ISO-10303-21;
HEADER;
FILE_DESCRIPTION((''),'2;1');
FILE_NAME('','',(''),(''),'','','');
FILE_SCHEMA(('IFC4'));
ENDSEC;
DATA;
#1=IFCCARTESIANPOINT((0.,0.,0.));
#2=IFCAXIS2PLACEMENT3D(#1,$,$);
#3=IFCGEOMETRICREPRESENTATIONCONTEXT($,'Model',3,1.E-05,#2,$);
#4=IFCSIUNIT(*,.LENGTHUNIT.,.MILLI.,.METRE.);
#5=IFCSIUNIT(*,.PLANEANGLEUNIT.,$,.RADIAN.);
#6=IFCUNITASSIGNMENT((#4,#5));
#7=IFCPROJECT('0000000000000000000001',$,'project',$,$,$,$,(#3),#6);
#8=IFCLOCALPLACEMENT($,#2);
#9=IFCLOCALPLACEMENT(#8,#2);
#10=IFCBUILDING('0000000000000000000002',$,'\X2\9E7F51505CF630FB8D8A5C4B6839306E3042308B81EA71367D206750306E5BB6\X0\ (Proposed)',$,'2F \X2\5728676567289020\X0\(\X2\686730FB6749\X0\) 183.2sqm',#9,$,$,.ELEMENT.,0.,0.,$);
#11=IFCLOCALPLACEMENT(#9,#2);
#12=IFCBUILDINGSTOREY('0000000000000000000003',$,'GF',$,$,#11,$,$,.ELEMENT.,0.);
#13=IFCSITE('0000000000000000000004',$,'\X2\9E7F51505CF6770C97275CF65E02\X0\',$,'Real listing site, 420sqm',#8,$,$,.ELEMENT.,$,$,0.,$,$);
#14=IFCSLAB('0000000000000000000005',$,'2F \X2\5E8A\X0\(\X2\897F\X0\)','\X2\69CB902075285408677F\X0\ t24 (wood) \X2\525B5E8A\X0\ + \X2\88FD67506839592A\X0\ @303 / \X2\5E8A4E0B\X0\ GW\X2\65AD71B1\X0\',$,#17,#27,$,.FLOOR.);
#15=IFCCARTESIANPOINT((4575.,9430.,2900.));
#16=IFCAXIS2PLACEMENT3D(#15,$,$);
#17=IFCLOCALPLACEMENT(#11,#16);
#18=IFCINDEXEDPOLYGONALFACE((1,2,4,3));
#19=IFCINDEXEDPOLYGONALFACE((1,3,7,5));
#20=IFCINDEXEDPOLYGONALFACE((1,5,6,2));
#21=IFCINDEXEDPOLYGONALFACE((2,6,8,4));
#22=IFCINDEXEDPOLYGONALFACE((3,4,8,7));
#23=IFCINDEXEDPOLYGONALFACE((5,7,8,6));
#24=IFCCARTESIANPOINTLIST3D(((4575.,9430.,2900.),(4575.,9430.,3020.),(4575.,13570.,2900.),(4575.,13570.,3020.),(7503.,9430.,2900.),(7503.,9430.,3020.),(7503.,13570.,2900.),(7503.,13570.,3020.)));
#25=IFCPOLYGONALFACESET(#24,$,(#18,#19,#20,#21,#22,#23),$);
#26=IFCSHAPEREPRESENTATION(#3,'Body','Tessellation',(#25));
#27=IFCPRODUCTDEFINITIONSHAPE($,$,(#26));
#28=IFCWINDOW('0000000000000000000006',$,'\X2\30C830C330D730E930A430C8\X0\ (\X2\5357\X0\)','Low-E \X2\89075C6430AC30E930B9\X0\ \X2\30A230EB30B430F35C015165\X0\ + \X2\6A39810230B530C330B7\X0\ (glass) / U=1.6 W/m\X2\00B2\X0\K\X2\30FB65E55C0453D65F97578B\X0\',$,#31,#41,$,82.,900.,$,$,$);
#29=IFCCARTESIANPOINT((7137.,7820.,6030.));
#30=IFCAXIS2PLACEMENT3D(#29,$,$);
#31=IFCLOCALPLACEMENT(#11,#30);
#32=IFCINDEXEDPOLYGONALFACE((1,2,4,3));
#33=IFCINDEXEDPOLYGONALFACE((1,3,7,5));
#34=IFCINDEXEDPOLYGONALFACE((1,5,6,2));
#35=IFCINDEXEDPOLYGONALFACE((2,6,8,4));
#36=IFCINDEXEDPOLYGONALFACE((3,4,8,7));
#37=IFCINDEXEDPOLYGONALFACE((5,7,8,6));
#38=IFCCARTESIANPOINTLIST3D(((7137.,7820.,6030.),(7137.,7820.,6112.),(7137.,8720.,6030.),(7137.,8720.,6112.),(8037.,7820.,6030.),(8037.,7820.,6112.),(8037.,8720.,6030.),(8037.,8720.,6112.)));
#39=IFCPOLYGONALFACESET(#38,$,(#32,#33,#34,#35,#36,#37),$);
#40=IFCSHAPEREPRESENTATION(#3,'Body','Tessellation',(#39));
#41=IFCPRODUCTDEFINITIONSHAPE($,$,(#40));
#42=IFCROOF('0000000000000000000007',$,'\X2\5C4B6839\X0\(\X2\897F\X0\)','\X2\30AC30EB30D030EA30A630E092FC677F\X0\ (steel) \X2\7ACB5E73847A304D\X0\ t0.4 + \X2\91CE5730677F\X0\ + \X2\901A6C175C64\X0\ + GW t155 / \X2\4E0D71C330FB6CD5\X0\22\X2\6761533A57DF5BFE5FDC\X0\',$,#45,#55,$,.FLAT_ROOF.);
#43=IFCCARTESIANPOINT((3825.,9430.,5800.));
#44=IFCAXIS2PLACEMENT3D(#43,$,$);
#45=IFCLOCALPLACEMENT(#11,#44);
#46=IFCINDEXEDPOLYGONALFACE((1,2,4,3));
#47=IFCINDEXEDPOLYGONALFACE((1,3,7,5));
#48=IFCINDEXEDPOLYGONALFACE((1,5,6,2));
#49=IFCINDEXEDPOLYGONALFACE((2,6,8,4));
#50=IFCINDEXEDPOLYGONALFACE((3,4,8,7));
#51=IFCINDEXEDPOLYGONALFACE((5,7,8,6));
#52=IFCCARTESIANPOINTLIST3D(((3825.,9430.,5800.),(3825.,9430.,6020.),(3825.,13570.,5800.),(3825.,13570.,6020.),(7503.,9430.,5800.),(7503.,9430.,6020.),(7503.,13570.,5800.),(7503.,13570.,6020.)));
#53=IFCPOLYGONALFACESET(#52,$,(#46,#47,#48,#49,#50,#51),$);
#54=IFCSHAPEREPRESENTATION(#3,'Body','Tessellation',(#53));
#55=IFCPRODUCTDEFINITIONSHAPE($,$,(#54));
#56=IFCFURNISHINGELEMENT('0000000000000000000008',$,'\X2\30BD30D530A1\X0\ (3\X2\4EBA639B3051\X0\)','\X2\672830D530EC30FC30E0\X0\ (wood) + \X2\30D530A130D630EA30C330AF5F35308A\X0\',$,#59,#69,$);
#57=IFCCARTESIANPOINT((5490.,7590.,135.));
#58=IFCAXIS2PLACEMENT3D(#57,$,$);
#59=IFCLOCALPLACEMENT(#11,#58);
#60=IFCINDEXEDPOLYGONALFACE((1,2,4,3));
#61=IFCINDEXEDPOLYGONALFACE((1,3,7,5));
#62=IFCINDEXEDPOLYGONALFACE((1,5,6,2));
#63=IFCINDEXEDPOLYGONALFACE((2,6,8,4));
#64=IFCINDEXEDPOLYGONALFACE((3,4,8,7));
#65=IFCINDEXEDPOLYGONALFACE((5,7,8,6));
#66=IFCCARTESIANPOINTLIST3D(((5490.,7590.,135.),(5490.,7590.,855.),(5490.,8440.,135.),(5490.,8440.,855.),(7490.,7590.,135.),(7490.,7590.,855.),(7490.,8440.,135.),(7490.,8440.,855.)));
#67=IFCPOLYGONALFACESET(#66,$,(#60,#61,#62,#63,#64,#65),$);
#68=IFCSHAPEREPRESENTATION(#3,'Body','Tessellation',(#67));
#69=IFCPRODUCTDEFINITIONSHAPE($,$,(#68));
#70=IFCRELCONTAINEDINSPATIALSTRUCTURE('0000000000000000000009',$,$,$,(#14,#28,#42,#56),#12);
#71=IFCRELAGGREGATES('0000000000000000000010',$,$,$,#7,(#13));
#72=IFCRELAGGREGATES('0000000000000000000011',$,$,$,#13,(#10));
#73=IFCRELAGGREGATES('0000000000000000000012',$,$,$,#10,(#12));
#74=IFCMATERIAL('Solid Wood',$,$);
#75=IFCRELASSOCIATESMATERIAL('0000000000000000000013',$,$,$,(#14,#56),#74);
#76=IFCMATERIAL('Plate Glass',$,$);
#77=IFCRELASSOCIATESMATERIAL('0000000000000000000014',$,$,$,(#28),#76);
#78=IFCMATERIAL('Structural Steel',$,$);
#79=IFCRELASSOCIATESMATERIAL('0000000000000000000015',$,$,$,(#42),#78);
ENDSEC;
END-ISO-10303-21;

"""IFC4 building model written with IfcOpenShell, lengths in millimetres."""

from ifc_helpers import new_model, si_unit, frame, frame_2d, origin, place, context, project, spatial, rectangle, extrude, material, element, save


model = new_model("IFC4")

# Units and contexts
model_context = context("Model", 3, precision=1e-05, world=origin())
ifc_project = project(units=[si_unit("LENGTHUNIT", "METRE", prefix="MILLI"), si_unit("PLANEANGLEUNIT", "RADIAN")], contexts=[model_context])

# Site, building, storey
site_placement = place(None, origin())
site = spatial("IfcSite", under=ifc_project, at=site_placement, Name="鹿児島県霧島市", ObjectType="Real listing site, 420sqm", CompositionType="ELEMENT", RefElevation=0.0)
building_placement = place(site_placement, origin())
building = spatial("IfcBuilding", under=site, at=building_placement, Name="鹿児島・越屋根のある自然素材の家 (Proposed)", ObjectType="2F 在来木造(桧・杉) 183.2sqm", CompositionType="ELEMENT", ElevationOfRefHeight=0.0, ElevationOfTerrain=0.0)
storey_placement = place(building_placement, origin())
storey = spatial("IfcBuildingStorey", under=building, at=storey_placement, Name="GF", CompositionType="ELEMENT", Elevation=0.0)

# Shared definitions
ifc_material_1 = material(Name="Solid Wood")

# Slab
slab_1_placement = place(storey_placement, frame((4575.0, 9430.0, 2900.0)))
element("IfcSlab", 1, at=slab_1_placement, inside=storey, material=ifc_material_1, Name="2F 床(西)", Description="構造用合板 t24 (wood) 剛床 + 製材根太 @303 / 床下 GW断熱", PredefinedType="FLOOR", context=model_context, shape_type="SweptSolid", body=[
    extrude(rectangle(XDim=2928.0, YDim=4140.0, at=frame_2d((1464.0, 2070.0))), frame((4575.0, 9430.0, 2900.0)), (0.0, 0.0, 1.0), 120.0),
])

# Window
ifc_material_2 = material(Name="Plate Glass")
window_placement = place(storey_placement, frame((7137.0, 7820.0, 6030.0)))
element("IfcWindow", 2, at=window_placement, inside=storey, material=ifc_material_2, Name="トップライト (南)", Description="Low-E 複層ガラス アルゴン封入 + 樹脂サッシ (glass) / U=1.6 W/m²K・日射取得型", OverallHeight=82.0, OverallWidth=900.0, context=model_context, shape_type="SweptSolid", body=[
    extrude(rectangle(XDim=900.0, YDim=900.0, at=frame_2d((450.0, 450.0))), frame((7137.0, 7820.0, 6030.0)), (0.0, 0.0, 1.0), 82.0),
])

# Roof
ifc_material_3 = material(Name="Structural Steel")
for number, where, name in (
    (3, (3825.0, 9430.0, 5800.0), "屋根(西)"),
):
    element("IfcRoof", number, at=place(storey_placement, frame(where)), inside=storey, material=ifc_material_3, Name=name, Description="ガルバリウム鋼板 (steel) 立平葺き t0.4 + 野地板 + 通気層 + GW t155 / 不燃・法22条区域対応", PredefinedType="FLAT_ROOF", context=model_context, shape_type="SweptSolid", body=[
        extrude(rectangle(XDim=3678.0, YDim=4140.0, at=frame_2d((1839.0, 2070.0))), frame((3825.0, 9430.0, 5800.0)), (0.0, 0.0, 1.0), 220.0),
    ])

# Furnishing element
furnishing_placement = place(storey_placement, frame((5490.0, 7590.0, 135.0)))
element("IfcFurnishingElement", 4, at=furnishing_placement, inside=storey, material=ifc_material_1, Name="ソファ (3人掛け)", Description="木フレーム (wood) + ファブリック張り", context=model_context, shape_type="SweptSolid", body=[
    extrude(rectangle(XDim=2000.0, YDim=850.0, at=frame_2d((1000.0, 425.0))), frame((5490.0, 7590.0, 135.0)), (0.0, 0.0, 1.0), 720.0),
])

save(model, "model.ifc")
